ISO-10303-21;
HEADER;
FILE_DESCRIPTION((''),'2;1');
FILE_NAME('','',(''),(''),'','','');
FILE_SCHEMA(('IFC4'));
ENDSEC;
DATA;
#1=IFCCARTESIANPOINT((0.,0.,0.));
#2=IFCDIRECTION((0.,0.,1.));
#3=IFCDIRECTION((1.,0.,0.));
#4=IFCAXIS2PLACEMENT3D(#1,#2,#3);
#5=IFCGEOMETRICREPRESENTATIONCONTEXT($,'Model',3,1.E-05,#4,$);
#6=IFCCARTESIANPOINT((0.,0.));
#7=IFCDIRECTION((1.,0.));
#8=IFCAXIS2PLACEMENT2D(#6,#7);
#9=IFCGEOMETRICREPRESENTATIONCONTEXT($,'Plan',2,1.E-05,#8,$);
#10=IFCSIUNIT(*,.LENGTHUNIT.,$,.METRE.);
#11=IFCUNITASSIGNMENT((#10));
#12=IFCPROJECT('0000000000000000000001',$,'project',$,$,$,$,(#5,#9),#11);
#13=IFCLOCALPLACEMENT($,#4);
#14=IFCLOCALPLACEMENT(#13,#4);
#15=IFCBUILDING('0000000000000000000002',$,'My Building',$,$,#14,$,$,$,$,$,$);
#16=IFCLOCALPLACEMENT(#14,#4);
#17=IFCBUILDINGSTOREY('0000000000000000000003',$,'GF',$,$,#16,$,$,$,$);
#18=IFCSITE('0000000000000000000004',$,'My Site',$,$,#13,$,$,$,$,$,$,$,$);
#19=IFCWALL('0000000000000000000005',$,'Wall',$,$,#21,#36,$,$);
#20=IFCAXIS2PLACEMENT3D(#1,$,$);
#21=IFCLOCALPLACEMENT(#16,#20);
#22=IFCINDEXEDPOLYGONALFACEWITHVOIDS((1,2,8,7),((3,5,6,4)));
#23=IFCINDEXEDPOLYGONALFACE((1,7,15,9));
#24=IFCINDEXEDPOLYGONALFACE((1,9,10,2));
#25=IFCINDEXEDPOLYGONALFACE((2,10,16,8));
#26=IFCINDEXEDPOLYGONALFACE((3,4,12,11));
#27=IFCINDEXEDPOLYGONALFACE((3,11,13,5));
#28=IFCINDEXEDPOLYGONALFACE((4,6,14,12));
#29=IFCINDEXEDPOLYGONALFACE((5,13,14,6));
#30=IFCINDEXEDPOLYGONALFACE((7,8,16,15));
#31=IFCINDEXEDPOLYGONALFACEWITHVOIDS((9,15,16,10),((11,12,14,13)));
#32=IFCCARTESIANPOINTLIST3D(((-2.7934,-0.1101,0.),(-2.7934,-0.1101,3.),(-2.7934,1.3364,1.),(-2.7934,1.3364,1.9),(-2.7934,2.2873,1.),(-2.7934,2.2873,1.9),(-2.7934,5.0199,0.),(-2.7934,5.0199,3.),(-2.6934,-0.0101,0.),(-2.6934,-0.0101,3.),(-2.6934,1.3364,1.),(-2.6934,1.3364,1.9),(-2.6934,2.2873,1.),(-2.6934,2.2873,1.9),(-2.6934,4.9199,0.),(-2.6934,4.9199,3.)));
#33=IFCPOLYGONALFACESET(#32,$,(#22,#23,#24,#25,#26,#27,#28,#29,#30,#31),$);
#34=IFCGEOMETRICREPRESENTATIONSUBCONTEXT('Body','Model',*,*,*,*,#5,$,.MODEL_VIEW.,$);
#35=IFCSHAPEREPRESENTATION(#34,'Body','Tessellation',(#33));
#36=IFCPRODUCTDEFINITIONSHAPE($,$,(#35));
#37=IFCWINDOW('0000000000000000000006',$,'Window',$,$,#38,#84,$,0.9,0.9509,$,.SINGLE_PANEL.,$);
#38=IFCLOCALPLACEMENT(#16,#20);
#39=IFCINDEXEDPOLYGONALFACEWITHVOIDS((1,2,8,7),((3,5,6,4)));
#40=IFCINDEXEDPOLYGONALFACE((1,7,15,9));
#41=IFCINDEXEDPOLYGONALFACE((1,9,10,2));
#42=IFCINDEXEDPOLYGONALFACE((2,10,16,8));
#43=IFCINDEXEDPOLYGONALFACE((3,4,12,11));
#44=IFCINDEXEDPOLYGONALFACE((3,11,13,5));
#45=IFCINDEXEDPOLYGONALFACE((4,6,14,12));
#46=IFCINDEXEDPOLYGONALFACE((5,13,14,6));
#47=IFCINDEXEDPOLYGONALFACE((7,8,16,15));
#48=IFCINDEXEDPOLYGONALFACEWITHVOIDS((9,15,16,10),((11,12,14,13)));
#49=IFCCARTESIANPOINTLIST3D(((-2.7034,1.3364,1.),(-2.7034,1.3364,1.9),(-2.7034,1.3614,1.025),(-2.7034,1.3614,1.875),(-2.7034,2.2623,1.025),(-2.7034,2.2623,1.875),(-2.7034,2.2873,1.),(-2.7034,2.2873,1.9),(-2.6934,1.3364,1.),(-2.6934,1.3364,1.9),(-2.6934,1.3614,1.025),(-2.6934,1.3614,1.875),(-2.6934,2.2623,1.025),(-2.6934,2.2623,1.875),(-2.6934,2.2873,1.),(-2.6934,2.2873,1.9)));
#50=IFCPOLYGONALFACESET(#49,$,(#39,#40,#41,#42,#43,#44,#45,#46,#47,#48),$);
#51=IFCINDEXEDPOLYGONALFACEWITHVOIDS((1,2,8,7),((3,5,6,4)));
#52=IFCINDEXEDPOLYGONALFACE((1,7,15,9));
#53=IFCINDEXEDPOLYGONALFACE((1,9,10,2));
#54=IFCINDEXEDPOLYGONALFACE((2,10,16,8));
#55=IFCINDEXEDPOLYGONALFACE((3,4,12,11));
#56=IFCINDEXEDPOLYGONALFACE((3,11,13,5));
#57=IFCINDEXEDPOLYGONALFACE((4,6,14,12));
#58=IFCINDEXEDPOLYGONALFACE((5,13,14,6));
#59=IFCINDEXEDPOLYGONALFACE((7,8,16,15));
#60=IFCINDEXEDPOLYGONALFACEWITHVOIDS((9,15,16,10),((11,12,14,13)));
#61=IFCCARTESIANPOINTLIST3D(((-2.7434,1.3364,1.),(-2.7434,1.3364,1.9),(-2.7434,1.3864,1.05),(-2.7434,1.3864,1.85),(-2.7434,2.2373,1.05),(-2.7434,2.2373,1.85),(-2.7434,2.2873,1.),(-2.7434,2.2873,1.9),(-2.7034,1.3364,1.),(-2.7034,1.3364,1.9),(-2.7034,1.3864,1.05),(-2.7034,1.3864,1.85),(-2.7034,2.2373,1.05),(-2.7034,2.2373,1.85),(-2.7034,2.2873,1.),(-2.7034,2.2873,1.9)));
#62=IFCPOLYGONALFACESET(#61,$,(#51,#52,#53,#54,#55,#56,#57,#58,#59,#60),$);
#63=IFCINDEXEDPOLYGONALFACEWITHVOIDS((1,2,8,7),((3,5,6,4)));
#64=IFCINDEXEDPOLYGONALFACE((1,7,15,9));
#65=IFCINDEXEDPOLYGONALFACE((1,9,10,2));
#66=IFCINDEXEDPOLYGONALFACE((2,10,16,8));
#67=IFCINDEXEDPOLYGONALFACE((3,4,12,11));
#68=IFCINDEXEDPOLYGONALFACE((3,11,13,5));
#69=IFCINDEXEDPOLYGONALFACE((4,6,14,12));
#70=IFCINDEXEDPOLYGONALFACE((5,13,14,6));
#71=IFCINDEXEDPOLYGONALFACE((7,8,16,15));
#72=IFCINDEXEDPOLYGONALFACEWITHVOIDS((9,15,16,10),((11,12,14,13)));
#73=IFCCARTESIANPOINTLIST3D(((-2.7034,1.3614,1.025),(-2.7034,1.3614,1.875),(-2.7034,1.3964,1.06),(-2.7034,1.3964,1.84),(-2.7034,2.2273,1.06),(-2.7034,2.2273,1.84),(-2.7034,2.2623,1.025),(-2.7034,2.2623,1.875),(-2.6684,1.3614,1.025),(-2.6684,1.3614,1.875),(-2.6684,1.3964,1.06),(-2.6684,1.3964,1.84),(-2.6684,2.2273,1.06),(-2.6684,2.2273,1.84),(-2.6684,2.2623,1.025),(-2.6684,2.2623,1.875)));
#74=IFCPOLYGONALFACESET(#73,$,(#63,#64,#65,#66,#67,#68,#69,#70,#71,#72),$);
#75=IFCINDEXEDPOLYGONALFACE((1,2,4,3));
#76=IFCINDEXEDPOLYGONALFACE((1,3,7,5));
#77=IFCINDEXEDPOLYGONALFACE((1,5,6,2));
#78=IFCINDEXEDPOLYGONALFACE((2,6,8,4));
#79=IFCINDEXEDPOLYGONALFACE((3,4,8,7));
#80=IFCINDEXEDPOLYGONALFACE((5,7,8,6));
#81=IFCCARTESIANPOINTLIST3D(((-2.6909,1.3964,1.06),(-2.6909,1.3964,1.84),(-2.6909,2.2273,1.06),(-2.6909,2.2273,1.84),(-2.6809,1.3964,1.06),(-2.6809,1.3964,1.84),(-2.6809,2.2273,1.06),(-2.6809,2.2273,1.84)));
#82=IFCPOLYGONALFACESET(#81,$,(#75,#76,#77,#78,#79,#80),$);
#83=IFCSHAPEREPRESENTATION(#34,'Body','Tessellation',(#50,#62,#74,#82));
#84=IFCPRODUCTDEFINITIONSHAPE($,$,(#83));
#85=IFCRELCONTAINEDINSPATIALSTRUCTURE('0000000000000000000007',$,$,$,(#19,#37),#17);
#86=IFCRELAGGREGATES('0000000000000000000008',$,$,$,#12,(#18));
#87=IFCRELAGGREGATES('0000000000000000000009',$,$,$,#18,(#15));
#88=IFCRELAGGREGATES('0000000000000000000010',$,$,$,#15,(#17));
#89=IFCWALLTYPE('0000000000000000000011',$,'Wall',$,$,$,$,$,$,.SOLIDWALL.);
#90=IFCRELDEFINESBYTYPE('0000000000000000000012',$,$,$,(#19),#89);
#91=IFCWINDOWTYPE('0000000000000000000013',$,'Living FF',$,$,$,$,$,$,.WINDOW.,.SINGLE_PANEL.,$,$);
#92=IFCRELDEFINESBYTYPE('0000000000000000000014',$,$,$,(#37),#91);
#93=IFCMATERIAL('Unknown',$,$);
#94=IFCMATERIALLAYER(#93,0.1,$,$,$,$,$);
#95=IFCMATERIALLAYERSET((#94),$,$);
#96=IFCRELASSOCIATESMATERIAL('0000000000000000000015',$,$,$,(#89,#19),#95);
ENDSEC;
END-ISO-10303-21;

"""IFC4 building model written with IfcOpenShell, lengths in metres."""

from ifc_helpers import new_model, entity, si_unit, frame, origin_with_axes, origin_2d_with_axis, place, context, subcontext, project, spatial, line, indexed_curve, outline, extrude, shape, source, transform, mapped, material, layer, layer_set, layer_usage, type_object, type_shapes, element, fill, save


model = new_model("IFC4")

# Units and contexts
model_context = context("Model", 3, precision=1e-05, world=origin_with_axes())
plan_context = context("Plan", 2, precision=1e-05, world=origin_2d_with_axis())
body_context_1 = subcontext(model_context, "Body", "Model", "MODEL_VIEW")
body_context_2 = subcontext(plan_context, "Body", "Plan", "PLAN_VIEW")
ifc_project = project(units=[si_unit("LENGTHUNIT", "METRE")], contexts=[model_context, plan_context])

# Site, building, storey
site_placement = place(None, origin_with_axes())
site = spatial("IfcSite", under=ifc_project, at=site_placement, Name="My Site")
building_placement = place(site_placement, origin_with_axes())
building = spatial("IfcBuilding", under=site, at=building_placement, Name="My Building")
storey_placement = place(building_placement, origin_with_axes())
storey = spatial("IfcBuildingStorey", under=building, at=storey_placement, Name="GF")

# Shared definitions
ifc_material = material(Name="Unknown")
ifc_layer = layer(ifc_material, 0.1)
ifc_layer_set = layer_set([ifc_layer])
wall_type = type_object("IfcWallType", Name="Wall", PredefinedType="SOLIDWALL", material=ifc_layer_set)
shared_shape_1 = source(origin_with_axes(), body_context_1, "Body", "SweptSolid", [
    extrude(outline(indexed_curve([(0.0, 0.0), (0.9509, 0.0), (0.9509, 0.9), (0.0, 0.9)], segments=[line(1, 2, 3, 4, 1)])), frame((0.0, -0.6, 0.0), z_axis=(0.0, -1.0, 0.0), x_axis=(1.0, 0.0, 0.0)), (0.0, 0.0, -1.0), 1.2),
])
window_type_1 = type_object("IfcWindowType", Name="Living FF", PartitioningType="SINGLE_PANEL", PredefinedType="WINDOW")
shared_shape_2 = source(origin_with_axes(), body_context_1, "Body", "SweptSolid", [
    extrude(outline(indexed_curve([(0.0, 0.0), (0.9509, 0.0), (0.9509, 0.9), (0.0, 0.9)], segments=[line(1, 2, 3, 4, 1)]), holes=[indexed_curve([(0.025, 0.025), (0.9259, 0.025), (0.9259, 0.875), (0.025, 0.875)], segments=[line(1, 2, 3, 4, 1)])]), frame((0.0, 0.09, 0.0), z_axis=(0.0, -1.0, 0.0), x_axis=(1.0, 0.0, 0.0)), (0.0, 0.0, -1.0), 0.01),
    extrude(outline(indexed_curve([(0.0, 0.0), (0.9509, 0.0), (0.9509, 0.9), (0.0, 0.9)], segments=[line(1, 2, 3, 4, 1)]), holes=[indexed_curve([(0.05, 0.05), (0.9009, 0.05), (0.9009, 0.85), (0.05, 0.85)], segments=[line(1, 2, 3, 4, 1)])]), frame((0.0, 0.05, 0.0), z_axis=(0.0, -1.0, 0.0), x_axis=(1.0, 0.0, 0.0)), (0.0, 0.0, -1.0), 0.04),
    extrude(outline(indexed_curve([(0.0, 0.0), (0.9009, 0.0), (0.9009, 0.85), (0.0, 0.85)], segments=[line(1, 2, 3, 4, 1)]), holes=[indexed_curve([(0.035, 0.035), (0.8659, 0.035), (0.8659, 0.815), (0.035, 0.815)], segments=[line(1, 2, 3, 4, 1)])]), frame((0.025, 0.09, 0.025), z_axis=(0.0, -1.0, 0.0), x_axis=(1.0, 0.0, 0.0)), (0.0, 0.0, -1.0), 0.035),
    extrude(outline(indexed_curve([(0.035, 0.035), (0.8659, 0.035), (0.8659, 0.815), (0.035, 0.815)], segments=[line(1, 2, 3, 4, 1)])), frame((0.025, 0.1025, 0.025), z_axis=(0.0, -1.0, 0.0), x_axis=(1.0, 0.0, 0.0)), (0.0, 0.0, -1.0), 0.01),
])
shared_shape_3 = source(origin_with_axes(), body_context_2, "Body", "Curve2D", [
    entity("IfcIndexedPolyCurve", entity("IfcCartesianPointList2D", [[0.05, 0.05], [0.9009, 0.05]])),
    entity("IfcIndexedPolyCurve", entity("IfcCartesianPointList2D", [[0.0, 0.1], [0.025, 0.1], [0.025, 0.09], [0.05, 0.09], [0.05, 0.05], [0.0, 0.05]]), [entity("IfcLineIndex", [1, 2, 3, 4, 5, 6, 1])]),
    entity("IfcIndexedPolyCurve", entity("IfcCartesianPointList2D", [[0.9509, 0.1], [0.9259, 0.1], [0.9259, 0.09], [0.9009, 0.09], [0.9009, 0.05], [0.9509, 0.05]]), [entity("IfcLineIndex", [1, 2, 3, 4, 5, 6, 1])]),
    entity("IfcIndexedPolyCurve", entity("IfcCartesianPointList2D", [[0.025, 0.09], [0.06, 0.09], [0.06, 0.125], [0.025, 0.125]]), [entity("IfcLineIndex", [1, 2, 3, 4, 1])]),
    entity("IfcIndexedPolyCurve", entity("IfcCartesianPointList2D", [[0.9259, 0.09], [0.8909, 0.09], [0.8909, 0.125], [0.9259, 0.125]]), [entity("IfcLineIndex", [1, 2, 3, 4, 1])]),
    entity("IfcIndexedPolyCurve", entity("IfcCartesianPointList2D", [[0.06, 0.09], [0.8909, 0.09]])),
    entity("IfcIndexedPolyCurve", entity("IfcCartesianPointList2D", [[0.06, 0.125], [0.8909, 0.125]])),
    entity("IfcIndexedPolyCurve", entity("IfcCartesianPointList2D", [[0.06, 0.1075], [0.8909, 0.1075]])),
])
type_shapes(window_type_1, [shared_shape_2, shared_shape_3])

# Wall, opening, window
ifc_layer_usage_1 = layer_usage(ifc_layer_set, "AXIS2", "POSITIVE", 0.0)
wall_1_placement = place(storey_placement, frame((-2.7934, 5.0199, 0.0), z_axis=(0.0, 0.0, 1.0), x_axis=(0.0, -1.0, 0.0)))
wall_1 = element("IfcWall", 1, at=wall_1_placement, inside=storey, type_object=wall_type, material=ifc_layer_usage_1, Name="Wall", context=body_context_1, shape_type="SweptSolid", body=[
    extrude(outline(indexed_curve([(0.0, 0.0), (0.1, 0.1), (5.03, 0.1), (5.13, 0.0)], segments=[line(1, 2, 3, 4, 1)])), origin_with_axes(), (0.0, 0.0, 1.0), 3.0),
])
opening_1_placement = place(wall_1_placement, frame((2.7326, 0.0, 1.0), z_axis=(0.0, 0.0, 1.0), x_axis=(1.0, 0.0, 0.0)))
opening_1 = element("IfcOpeningElement", 2, at=opening_1_placement, cuts=wall_1, PredefinedType="OPENING", context=body_context_1, shape_type="MappedRepresentation", body=[
    mapped(shared_shape_1, transform((0.0, 0.0, 0.0), x_axis=(1.0, 0.0, 0.0), y_axis=(0.0, 1.0, 0.0), z_axis=(0.0, 0.0, 1.0), scale=1.0)),
])
window_1_placement = place(opening_1_placement, frame((0.0, 0.0, 0.0), z_axis=(0.0, 0.0, 1.0), x_axis=(1.0, 0.0, 0.0)))
window_1 = element("IfcWindow", 3, at=window_1_placement, inside=storey, type_object=window_type_1, Name="Window", OverallHeight=0.9, OverallWidth=0.9509, PartitioningType="SINGLE_PANEL", shapes=[
    shape(body_context_1, "Body", "MappedRepresentation", [mapped(shared_shape_2, transform((0.0, 0.0, 0.0), x_axis=(1.0, 0.0, 0.0), y_axis=(0.0, 1.0, 0.0), z_axis=(0.0, 0.0, 1.0), scale=1.0))]),
    shape(body_context_2, "Body", "MappedRepresentation", [mapped(shared_shape_3, transform((0.0, 0.0, 0.0), x_axis=(1.0, 0.0, 0.0), y_axis=(0.0, 1.0, 0.0), z_axis=(0.0, 0.0, 1.0), scale=1.0))]),
])
fill(opening_1, window_1)

save(model, "model.ifc")
